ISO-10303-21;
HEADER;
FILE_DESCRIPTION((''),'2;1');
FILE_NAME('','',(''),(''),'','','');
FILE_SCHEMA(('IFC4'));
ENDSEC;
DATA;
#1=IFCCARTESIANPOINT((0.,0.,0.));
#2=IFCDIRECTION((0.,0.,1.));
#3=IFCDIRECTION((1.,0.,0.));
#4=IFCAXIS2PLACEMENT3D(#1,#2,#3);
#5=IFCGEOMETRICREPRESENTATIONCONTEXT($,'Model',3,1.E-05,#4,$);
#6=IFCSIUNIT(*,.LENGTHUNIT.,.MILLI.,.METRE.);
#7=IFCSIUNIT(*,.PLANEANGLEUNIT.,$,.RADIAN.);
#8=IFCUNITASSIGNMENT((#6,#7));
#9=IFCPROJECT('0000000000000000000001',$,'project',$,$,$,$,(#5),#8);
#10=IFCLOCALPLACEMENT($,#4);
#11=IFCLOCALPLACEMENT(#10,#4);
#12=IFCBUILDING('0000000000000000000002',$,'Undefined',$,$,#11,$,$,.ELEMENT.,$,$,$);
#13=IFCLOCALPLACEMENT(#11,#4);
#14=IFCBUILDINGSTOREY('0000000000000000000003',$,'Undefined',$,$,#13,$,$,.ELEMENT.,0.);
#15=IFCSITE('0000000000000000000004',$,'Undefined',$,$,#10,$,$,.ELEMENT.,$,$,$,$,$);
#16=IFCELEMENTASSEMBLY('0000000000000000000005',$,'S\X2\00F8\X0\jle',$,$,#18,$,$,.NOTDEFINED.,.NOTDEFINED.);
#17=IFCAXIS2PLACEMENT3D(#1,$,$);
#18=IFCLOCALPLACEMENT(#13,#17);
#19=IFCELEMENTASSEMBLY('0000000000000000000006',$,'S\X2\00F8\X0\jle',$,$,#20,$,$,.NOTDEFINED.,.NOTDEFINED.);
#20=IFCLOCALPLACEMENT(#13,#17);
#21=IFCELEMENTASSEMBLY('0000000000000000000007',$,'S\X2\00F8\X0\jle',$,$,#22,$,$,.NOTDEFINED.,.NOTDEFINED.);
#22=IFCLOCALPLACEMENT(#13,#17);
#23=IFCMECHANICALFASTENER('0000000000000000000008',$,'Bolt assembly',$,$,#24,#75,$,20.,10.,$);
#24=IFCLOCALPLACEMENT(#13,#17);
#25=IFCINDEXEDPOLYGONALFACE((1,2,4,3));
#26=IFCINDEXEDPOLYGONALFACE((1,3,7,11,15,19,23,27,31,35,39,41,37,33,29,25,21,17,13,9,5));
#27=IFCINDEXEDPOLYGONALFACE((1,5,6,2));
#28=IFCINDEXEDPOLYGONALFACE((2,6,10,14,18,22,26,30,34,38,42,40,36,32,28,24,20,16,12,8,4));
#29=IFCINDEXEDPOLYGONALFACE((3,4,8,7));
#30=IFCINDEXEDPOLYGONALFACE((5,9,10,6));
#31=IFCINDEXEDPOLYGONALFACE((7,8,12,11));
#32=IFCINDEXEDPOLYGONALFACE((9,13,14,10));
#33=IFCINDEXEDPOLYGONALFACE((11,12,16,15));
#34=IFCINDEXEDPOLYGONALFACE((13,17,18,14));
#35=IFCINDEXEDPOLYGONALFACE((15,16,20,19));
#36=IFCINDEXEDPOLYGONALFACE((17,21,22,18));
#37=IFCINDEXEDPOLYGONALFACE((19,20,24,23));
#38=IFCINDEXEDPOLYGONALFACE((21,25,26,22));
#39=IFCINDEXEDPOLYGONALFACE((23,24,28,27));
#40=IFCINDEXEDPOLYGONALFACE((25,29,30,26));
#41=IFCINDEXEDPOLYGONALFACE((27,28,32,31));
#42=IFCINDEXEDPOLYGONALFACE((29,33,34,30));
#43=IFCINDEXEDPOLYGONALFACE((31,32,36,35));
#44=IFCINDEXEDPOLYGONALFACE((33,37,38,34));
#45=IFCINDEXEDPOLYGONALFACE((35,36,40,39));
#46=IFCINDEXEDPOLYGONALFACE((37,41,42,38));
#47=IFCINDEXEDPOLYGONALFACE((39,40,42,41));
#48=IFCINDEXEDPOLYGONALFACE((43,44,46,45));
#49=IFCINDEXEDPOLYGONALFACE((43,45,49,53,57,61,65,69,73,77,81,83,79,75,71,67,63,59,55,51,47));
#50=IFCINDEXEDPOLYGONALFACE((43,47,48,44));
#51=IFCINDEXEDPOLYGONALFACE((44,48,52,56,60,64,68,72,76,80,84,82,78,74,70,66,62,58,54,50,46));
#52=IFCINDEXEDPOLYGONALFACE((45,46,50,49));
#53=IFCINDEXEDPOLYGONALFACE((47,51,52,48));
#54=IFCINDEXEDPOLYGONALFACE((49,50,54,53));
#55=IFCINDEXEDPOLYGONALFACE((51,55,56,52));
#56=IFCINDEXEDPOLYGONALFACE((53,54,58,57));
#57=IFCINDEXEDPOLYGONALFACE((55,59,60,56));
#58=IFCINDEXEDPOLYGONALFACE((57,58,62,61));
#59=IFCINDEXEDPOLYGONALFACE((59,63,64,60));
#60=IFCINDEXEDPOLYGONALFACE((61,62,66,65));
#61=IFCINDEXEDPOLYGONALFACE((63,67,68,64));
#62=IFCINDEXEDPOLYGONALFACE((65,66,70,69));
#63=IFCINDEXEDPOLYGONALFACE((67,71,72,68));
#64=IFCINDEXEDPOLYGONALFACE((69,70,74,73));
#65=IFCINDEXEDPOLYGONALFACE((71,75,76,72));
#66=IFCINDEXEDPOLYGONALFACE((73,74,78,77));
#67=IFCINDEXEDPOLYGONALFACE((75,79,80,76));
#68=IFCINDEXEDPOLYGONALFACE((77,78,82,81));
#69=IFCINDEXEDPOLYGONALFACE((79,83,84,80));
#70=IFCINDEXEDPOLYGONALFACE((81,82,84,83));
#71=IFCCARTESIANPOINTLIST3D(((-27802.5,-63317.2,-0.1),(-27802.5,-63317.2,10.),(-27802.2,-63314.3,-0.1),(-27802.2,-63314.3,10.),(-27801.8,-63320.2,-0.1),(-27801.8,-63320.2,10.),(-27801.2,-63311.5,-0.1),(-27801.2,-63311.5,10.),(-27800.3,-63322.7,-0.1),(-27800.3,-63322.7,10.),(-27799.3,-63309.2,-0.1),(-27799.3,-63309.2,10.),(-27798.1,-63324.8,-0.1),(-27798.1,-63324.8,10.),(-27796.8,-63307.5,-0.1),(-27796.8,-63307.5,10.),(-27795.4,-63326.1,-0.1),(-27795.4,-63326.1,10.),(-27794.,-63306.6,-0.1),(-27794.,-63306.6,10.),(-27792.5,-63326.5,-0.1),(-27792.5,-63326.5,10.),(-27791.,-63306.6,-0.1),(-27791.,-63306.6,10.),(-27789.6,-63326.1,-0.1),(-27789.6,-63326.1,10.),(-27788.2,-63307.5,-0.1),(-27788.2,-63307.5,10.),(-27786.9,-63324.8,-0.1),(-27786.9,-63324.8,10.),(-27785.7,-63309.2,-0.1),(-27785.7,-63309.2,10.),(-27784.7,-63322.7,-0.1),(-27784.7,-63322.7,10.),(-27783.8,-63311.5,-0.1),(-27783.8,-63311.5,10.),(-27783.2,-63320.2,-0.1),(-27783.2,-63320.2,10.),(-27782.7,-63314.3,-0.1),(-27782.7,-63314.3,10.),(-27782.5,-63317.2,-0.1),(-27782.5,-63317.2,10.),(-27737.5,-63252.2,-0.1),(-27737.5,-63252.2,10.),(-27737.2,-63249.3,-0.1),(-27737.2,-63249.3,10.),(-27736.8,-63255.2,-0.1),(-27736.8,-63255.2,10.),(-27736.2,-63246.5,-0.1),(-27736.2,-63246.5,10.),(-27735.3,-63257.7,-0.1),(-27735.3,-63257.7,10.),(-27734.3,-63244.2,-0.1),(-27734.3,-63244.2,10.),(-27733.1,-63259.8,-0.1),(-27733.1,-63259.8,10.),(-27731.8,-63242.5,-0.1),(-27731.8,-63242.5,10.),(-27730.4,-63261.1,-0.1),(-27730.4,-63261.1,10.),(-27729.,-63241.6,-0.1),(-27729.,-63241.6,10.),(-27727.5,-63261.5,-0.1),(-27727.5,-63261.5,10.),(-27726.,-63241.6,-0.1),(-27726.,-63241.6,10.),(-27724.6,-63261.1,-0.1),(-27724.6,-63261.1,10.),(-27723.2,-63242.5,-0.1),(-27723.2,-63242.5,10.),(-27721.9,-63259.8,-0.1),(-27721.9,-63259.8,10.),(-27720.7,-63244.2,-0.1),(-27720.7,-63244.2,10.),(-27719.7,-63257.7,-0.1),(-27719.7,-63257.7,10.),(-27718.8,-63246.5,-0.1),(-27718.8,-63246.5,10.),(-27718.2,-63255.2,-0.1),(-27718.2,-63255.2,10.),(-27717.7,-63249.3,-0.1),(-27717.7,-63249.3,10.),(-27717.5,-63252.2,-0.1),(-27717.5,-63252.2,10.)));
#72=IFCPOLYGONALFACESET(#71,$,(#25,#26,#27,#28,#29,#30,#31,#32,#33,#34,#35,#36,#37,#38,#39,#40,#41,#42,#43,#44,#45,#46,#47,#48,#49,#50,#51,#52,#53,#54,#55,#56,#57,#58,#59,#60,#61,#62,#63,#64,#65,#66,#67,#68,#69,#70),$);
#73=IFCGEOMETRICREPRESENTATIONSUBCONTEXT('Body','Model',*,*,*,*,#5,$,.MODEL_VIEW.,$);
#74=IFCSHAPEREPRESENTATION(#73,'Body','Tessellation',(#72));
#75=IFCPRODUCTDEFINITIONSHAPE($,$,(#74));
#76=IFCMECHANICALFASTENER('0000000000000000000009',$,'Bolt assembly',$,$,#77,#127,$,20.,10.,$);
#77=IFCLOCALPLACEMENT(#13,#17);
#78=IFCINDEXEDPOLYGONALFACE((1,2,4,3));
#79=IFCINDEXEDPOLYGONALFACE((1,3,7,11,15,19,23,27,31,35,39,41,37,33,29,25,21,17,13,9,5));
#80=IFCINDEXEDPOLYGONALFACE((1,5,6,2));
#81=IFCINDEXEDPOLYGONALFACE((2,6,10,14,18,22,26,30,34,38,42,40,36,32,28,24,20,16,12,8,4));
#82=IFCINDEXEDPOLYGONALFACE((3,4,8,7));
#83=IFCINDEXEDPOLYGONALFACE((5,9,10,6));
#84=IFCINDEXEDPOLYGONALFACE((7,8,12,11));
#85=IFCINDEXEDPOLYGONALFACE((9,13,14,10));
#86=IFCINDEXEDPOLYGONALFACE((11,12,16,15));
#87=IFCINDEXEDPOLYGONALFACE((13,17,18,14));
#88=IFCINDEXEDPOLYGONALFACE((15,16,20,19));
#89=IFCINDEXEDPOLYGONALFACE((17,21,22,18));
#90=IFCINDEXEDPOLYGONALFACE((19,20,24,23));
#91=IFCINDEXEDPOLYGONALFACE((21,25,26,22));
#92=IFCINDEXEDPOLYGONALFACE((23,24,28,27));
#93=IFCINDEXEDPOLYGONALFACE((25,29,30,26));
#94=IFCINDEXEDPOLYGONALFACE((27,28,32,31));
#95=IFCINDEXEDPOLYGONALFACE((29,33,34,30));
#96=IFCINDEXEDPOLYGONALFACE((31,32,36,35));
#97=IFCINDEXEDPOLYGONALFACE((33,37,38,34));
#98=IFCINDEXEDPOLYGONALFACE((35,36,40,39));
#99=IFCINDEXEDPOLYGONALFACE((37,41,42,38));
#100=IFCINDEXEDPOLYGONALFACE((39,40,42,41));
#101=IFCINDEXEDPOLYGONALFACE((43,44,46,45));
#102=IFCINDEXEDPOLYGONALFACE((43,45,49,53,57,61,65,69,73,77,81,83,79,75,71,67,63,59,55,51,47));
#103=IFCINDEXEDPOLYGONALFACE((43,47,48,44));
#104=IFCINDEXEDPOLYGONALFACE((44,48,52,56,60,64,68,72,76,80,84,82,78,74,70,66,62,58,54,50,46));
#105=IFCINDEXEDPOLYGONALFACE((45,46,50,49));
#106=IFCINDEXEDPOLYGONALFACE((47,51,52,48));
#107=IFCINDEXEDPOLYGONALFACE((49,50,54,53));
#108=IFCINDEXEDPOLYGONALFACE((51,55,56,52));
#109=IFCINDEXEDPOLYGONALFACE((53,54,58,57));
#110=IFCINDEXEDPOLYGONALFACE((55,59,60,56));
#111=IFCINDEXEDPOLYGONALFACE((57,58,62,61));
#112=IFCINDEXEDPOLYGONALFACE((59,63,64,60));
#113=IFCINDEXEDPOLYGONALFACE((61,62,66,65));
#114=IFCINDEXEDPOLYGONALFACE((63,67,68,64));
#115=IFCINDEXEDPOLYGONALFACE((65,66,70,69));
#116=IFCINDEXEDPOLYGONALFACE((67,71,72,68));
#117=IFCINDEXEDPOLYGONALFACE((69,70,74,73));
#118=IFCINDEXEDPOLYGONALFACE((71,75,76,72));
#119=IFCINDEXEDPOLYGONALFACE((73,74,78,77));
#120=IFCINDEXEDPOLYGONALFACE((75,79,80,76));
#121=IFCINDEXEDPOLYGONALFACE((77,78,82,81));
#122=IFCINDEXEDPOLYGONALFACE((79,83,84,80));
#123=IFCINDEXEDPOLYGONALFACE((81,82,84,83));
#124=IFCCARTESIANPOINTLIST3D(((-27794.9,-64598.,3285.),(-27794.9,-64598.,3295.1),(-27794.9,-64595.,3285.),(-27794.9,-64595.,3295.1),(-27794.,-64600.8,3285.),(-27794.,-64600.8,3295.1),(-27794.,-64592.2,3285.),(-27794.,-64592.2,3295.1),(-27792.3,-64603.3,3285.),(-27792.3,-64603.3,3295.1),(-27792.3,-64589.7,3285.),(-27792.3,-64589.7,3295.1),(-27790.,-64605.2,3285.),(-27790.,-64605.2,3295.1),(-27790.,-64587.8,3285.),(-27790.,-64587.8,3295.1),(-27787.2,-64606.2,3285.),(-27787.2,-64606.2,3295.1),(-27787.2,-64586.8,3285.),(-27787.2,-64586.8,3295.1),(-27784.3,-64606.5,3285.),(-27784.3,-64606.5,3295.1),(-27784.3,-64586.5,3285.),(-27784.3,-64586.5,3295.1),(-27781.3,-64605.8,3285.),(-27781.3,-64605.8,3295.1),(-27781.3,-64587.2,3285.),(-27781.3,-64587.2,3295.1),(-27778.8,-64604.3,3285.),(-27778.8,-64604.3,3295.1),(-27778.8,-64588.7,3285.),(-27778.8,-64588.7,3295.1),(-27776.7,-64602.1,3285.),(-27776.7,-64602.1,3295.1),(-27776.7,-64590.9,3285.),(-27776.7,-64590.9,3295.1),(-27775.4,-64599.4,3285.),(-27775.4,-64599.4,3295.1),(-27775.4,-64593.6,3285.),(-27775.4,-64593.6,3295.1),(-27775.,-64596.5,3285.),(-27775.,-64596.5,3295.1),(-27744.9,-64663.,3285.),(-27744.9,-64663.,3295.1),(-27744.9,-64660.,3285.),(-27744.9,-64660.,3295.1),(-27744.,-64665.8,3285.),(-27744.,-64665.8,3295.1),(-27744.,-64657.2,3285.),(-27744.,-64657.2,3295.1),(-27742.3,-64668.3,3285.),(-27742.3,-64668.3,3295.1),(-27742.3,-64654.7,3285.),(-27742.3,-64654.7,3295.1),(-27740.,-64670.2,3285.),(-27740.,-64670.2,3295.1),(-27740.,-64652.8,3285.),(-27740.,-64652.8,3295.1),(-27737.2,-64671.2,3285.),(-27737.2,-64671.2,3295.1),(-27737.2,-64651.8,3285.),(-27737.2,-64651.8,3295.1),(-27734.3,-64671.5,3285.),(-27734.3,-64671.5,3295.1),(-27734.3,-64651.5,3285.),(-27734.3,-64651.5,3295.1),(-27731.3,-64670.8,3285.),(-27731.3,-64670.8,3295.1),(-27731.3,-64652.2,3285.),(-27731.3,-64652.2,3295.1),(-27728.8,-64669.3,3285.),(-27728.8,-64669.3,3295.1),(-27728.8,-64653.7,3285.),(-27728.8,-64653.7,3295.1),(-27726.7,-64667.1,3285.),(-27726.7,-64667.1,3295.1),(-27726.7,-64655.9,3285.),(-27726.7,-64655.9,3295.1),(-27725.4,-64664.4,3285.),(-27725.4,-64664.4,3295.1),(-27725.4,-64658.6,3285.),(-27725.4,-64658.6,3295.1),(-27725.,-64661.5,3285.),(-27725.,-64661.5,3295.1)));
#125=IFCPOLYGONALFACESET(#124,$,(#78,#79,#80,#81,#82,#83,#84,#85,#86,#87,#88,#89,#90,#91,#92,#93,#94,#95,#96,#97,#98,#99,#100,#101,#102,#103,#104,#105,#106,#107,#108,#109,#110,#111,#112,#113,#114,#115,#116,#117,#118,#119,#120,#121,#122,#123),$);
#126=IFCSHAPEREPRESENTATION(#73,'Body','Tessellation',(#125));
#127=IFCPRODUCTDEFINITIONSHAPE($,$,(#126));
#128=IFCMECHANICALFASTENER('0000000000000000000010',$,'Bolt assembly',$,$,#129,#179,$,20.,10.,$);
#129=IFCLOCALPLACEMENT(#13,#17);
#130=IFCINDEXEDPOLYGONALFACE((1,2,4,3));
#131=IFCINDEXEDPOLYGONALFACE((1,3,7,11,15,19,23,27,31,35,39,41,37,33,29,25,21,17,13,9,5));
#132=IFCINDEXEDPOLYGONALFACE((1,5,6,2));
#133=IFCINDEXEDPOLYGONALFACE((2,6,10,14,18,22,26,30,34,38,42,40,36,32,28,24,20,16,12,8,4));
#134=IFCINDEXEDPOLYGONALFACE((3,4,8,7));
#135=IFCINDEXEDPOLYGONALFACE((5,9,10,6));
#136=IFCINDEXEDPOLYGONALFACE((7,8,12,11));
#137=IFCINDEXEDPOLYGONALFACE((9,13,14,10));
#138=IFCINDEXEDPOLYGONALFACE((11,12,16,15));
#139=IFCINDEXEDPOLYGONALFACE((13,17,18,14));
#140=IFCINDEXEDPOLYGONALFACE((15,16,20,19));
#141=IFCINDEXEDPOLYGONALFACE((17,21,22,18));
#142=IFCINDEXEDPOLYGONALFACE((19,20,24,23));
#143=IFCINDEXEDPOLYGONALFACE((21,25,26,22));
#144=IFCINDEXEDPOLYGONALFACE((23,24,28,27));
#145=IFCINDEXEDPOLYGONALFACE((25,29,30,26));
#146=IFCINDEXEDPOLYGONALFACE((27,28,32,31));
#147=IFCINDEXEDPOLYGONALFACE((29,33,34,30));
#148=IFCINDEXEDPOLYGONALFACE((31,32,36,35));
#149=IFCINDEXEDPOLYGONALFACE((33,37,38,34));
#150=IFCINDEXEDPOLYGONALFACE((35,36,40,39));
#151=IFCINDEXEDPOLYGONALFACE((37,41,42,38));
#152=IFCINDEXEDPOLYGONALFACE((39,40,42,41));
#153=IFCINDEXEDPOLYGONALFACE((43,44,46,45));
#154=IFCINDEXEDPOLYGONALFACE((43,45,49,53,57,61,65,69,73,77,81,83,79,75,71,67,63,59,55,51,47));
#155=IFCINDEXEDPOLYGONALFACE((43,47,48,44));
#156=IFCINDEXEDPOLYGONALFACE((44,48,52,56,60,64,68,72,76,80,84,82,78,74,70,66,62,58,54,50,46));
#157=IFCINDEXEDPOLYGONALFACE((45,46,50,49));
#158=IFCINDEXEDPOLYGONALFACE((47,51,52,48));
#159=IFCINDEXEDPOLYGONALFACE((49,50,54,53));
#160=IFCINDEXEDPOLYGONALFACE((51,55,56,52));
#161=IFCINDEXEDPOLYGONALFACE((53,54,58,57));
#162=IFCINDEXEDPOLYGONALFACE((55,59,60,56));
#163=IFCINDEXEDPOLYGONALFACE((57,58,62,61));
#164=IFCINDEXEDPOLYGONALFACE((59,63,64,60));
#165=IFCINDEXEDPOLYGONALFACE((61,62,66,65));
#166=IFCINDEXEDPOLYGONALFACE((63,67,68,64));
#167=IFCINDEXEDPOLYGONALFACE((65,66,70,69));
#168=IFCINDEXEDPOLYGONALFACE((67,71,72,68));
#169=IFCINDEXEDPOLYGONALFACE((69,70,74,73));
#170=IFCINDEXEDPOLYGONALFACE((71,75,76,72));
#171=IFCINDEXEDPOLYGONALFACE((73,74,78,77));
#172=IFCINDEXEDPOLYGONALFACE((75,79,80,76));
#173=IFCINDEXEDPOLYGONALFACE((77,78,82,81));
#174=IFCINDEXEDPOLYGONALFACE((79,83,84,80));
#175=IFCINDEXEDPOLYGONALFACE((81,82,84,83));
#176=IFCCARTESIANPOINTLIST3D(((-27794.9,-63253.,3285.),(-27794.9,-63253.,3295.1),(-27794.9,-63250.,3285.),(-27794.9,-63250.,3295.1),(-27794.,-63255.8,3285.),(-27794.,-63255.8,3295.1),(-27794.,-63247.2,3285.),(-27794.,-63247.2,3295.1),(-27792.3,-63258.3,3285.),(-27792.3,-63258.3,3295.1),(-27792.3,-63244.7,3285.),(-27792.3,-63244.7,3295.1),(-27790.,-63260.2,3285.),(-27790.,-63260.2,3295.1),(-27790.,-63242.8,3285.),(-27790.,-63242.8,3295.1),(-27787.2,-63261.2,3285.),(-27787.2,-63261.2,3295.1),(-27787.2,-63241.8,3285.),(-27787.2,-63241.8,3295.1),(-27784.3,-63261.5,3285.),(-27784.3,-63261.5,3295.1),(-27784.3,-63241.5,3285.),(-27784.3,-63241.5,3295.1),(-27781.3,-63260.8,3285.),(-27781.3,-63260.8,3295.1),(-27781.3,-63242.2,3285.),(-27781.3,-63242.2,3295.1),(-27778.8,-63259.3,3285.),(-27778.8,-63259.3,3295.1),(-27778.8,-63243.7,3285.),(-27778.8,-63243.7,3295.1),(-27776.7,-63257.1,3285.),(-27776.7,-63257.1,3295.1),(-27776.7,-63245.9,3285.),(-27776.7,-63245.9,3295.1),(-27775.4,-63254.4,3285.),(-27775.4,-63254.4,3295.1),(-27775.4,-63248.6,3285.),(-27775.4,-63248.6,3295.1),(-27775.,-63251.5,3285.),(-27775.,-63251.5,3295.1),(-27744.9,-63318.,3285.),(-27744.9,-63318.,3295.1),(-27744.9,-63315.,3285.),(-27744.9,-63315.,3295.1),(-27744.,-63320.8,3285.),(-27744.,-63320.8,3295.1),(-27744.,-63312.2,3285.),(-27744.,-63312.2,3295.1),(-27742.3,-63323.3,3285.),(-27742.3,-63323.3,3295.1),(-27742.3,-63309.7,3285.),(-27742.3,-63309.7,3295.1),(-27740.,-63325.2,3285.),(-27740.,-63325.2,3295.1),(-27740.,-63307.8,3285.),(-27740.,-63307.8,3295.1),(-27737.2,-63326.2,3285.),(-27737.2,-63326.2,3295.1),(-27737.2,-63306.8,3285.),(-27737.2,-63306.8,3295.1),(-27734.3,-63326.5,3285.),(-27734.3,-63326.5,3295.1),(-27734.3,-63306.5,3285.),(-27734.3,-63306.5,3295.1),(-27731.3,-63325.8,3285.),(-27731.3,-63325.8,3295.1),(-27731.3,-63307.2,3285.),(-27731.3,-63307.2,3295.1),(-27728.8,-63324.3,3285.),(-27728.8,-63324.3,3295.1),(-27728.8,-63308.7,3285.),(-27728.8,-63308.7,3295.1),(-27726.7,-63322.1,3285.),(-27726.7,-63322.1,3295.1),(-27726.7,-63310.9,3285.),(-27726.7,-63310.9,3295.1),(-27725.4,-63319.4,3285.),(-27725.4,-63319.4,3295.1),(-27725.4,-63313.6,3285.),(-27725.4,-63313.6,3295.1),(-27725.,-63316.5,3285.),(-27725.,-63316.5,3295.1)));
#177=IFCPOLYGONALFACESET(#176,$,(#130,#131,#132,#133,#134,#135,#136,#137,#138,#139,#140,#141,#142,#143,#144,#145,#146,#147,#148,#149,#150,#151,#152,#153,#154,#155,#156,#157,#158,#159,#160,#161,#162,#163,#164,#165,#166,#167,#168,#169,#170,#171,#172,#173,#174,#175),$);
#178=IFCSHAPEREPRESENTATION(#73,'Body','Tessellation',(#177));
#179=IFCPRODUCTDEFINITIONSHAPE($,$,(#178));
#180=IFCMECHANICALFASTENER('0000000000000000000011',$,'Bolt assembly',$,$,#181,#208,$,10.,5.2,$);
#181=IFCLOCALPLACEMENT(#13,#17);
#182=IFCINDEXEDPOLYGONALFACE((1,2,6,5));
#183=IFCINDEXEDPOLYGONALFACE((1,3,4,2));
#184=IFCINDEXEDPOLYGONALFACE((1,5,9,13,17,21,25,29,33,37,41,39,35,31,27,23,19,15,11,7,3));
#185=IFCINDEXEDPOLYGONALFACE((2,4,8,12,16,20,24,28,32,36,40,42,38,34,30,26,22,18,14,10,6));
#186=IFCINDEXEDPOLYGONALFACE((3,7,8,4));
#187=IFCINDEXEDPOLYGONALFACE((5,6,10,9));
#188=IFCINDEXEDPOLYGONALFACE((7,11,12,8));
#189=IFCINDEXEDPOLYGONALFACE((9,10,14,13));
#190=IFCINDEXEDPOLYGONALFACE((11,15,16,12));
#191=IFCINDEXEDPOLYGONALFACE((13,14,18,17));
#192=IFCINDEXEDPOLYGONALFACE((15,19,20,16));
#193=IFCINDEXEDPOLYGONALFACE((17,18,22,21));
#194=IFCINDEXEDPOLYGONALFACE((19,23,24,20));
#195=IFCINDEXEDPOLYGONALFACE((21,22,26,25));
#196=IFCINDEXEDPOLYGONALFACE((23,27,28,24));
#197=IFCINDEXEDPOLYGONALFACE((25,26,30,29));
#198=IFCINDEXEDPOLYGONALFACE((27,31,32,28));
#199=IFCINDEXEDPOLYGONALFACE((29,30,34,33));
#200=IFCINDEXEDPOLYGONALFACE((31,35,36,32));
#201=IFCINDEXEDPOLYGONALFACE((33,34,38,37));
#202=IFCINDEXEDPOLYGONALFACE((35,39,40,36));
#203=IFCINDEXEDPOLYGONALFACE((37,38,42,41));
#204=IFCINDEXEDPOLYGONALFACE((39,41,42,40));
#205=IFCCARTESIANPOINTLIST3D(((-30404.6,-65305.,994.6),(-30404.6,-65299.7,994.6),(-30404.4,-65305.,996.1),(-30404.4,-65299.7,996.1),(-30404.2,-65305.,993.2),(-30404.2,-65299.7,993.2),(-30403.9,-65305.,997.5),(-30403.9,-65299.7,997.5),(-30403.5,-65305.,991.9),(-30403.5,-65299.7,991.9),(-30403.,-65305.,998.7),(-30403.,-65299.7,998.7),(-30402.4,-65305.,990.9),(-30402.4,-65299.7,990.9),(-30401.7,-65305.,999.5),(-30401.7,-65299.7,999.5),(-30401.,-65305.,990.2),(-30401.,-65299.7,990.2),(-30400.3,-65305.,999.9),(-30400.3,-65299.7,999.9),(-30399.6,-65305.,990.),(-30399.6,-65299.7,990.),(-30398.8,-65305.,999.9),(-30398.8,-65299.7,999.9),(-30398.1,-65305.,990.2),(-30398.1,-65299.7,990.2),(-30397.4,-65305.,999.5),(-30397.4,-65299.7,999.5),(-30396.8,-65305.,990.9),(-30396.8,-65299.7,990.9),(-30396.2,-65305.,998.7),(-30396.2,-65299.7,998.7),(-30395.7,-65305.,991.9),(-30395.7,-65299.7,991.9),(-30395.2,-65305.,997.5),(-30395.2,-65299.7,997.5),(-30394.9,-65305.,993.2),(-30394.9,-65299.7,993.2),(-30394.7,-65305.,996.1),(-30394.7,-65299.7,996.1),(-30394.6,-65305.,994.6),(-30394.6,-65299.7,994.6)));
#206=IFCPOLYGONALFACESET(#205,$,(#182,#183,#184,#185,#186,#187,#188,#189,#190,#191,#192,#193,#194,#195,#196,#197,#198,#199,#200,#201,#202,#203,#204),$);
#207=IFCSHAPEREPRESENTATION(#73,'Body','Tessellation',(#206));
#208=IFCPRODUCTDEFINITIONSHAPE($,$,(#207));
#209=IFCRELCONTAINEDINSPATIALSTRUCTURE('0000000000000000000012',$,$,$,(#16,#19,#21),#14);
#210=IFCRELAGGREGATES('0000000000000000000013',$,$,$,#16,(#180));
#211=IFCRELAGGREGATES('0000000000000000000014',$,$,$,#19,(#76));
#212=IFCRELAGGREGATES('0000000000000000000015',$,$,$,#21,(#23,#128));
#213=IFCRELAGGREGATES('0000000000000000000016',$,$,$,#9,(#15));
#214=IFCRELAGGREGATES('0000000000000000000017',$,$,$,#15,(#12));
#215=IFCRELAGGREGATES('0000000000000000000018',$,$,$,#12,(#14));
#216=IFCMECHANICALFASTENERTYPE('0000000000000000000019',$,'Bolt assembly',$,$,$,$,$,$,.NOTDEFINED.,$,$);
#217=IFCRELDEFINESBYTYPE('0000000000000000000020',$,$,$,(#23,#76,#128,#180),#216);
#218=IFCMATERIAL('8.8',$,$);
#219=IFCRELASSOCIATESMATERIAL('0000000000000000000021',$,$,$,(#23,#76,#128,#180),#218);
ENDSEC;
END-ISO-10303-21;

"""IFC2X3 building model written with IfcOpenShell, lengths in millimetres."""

from ifc_helpers import new_model, si_unit, frame, origin_with_axes, origin_2d_with_axis, place, context, subcontext, project, spatial, circle, extrude, source, transform, mapped, material, type_object, element, aggregate, save


model = new_model("IFC2X3")

# Units and contexts
model_context = context("Model", 3, precision=1e-05, world=origin_with_axes())
body_context = subcontext(model_context, "Body", "Model", "MODEL_VIEW")
ifc_project = project(units=[si_unit("LENGTHUNIT", "METRE", prefix="MILLI"), si_unit("PLANEANGLEUNIT", "RADIAN")], contexts=[model_context])

# Site, building, storey
site_placement = place(None, origin_with_axes())
site = spatial("IfcSite", under=ifc_project, at=site_placement, Name="Undefined", CompositionType="ELEMENT")
building_placement = place(site_placement, origin_with_axes())
building = spatial("IfcBuilding", under=site, at=building_placement, Name="Undefined", CompositionType="ELEMENT")
storey_placement = place(building_placement, origin_with_axes())
storey = spatial("IfcBuildingStorey", under=building, at=storey_placement, Name="Undefined", CompositionType="ELEMENT", Elevation=0.0)

# Element assembly
assembly_1_placement = place(storey_placement, origin_with_axes())
assembly_1 = element("IfcElementAssembly", 1, at=assembly_1_placement, inside=storey, Name="Søjle", AssemblyPlace="NOTDEFINED", PredefinedType="NOTDEFINED")

# Shared definitions
ifc_material_1 = material(Name="8.8")
mechanical_fastener_type = type_object("IfcMechanicalFastenerType", Name="Bolt assembly")
shared_shape_1 = source(origin_with_axes(), body_context, "Body", "SweptSolid", [
    extrude(circle(Radius=10.0, at=origin_2d_with_axis()), frame((0.0, 0.0, 0.0), z_axis=(0.0, 1.0, 0.0), x_axis=(1.0, 0.0, 0.0)), (0.0, 0.0, 1.0), 10.1),
])

# Element assemblies, mechanical fastener
assembly_2_placement = place(storey_placement, origin_with_axes())
assembly_2 = element("IfcElementAssembly", 2, at=assembly_2_placement, inside=storey, Name="Søjle", AssemblyPlace="NOTDEFINED", PredefinedType="NOTDEFINED")
assembly_3_placement = place(storey_placement, origin_with_axes())
assembly_3 = element("IfcElementAssembly", 3, at=assembly_3_placement, inside=storey, Name="Søjle", AssemblyPlace="NOTDEFINED", PredefinedType="NOTDEFINED")
mechanical_fastener_1_placement = place(assembly_3_placement, frame((-27760.0, -63251.5, 10.0), z_axis=(1.0, 0.0, 0.0), x_axis=(0.0, -1.0, 0.0)))
mechanical_fastener_1 = element("IfcMechanicalFastener", 4, at=mechanical_fastener_1_placement, type_object=mechanical_fastener_type, material=ifc_material_1, Name="Bolt assembly", NominalDiameter=20.0, NominalLength=10.0, context=body_context, shape_type="MappedRepresentation", body=[
    mapped(shared_shape_1, transform((65.0, 0.0, -32.5))),
    mapped(shared_shape_1, transform((0.0, 0.0, 32.5))),
])

# Mechanical fasteners
mechanical_fastener_2_placement = place(assembly_2_placement, frame((-27785.0, -64629.0, 3285.0), z_axis=(0.0, -1.0, 0.0), x_axis=(1.0, 0.0, 0.0)))
mechanical_fastener_2 = element("IfcMechanicalFastener", 5, at=mechanical_fastener_2_placement, type_object=mechanical_fastener_type, material=ifc_material_1, Name="Bolt assembly", NominalDiameter=20.0, NominalLength=10.0, context=body_context, shape_type="MappedRepresentation", body=[
    mapped(shared_shape_1, transform((0.0, 0.0, -32.5))),
    mapped(shared_shape_1, transform((50.0, 0.0, 32.5))),
])
mechanical_fastener_3_placement = place(assembly_3_placement, frame((-27785.0, -63284.0, 3285.0), z_axis=(0.0, -1.0, 0.0), x_axis=(1.0, 0.0, 0.0)))
mechanical_fastener_3 = element("IfcMechanicalFastener", 6, at=mechanical_fastener_3_placement, type_object=mechanical_fastener_type, material=ifc_material_1, Name="Bolt assembly", NominalDiameter=20.0, NominalLength=10.0, context=body_context, shape_type="MappedRepresentation", body=[
    mapped(shared_shape_1, transform((0.0, 0.0, -32.5))),
    mapped(shared_shape_1, transform((50.0, 0.0, 32.5))),
])
shared_shape_2 = source(origin_with_axes(), body_context, "Body", "SweptSolid", [
    extrude(circle(Radius=5.0, at=origin_2d_with_axis()), frame((0.0, 0.0, 0.0), z_axis=(0.0, 1.0, 0.0), x_axis=(1.0, 0.0, 0.0)), (0.0, 0.0, 1.0), 5.3),
])
mechanical_fastener_4_placement = place(assembly_1_placement, frame((-30399.6, -65299.7, 995.0), z_axis=(-1.0, 0.0, 0.0), x_axis=(0.0, 0.0, -1.0)))
mechanical_fastener_4 = element("IfcMechanicalFastener", 7, at=mechanical_fastener_4_placement, type_object=mechanical_fastener_type, material=ifc_material_1, Name="Bolt assembly", NominalDiameter=10.0, NominalLength=5.2, context=body_context, shape_type="MappedRepresentation", body=[
    mapped(shared_shape_2, transform((0.0, 0.0, 0.0))),
])
aggregate(assembly_1, [mechanical_fastener_4])
aggregate(assembly_2, [mechanical_fastener_2])
aggregate(assembly_3, [mechanical_fastener_1, mechanical_fastener_3])

save(model, "model.ifc")
